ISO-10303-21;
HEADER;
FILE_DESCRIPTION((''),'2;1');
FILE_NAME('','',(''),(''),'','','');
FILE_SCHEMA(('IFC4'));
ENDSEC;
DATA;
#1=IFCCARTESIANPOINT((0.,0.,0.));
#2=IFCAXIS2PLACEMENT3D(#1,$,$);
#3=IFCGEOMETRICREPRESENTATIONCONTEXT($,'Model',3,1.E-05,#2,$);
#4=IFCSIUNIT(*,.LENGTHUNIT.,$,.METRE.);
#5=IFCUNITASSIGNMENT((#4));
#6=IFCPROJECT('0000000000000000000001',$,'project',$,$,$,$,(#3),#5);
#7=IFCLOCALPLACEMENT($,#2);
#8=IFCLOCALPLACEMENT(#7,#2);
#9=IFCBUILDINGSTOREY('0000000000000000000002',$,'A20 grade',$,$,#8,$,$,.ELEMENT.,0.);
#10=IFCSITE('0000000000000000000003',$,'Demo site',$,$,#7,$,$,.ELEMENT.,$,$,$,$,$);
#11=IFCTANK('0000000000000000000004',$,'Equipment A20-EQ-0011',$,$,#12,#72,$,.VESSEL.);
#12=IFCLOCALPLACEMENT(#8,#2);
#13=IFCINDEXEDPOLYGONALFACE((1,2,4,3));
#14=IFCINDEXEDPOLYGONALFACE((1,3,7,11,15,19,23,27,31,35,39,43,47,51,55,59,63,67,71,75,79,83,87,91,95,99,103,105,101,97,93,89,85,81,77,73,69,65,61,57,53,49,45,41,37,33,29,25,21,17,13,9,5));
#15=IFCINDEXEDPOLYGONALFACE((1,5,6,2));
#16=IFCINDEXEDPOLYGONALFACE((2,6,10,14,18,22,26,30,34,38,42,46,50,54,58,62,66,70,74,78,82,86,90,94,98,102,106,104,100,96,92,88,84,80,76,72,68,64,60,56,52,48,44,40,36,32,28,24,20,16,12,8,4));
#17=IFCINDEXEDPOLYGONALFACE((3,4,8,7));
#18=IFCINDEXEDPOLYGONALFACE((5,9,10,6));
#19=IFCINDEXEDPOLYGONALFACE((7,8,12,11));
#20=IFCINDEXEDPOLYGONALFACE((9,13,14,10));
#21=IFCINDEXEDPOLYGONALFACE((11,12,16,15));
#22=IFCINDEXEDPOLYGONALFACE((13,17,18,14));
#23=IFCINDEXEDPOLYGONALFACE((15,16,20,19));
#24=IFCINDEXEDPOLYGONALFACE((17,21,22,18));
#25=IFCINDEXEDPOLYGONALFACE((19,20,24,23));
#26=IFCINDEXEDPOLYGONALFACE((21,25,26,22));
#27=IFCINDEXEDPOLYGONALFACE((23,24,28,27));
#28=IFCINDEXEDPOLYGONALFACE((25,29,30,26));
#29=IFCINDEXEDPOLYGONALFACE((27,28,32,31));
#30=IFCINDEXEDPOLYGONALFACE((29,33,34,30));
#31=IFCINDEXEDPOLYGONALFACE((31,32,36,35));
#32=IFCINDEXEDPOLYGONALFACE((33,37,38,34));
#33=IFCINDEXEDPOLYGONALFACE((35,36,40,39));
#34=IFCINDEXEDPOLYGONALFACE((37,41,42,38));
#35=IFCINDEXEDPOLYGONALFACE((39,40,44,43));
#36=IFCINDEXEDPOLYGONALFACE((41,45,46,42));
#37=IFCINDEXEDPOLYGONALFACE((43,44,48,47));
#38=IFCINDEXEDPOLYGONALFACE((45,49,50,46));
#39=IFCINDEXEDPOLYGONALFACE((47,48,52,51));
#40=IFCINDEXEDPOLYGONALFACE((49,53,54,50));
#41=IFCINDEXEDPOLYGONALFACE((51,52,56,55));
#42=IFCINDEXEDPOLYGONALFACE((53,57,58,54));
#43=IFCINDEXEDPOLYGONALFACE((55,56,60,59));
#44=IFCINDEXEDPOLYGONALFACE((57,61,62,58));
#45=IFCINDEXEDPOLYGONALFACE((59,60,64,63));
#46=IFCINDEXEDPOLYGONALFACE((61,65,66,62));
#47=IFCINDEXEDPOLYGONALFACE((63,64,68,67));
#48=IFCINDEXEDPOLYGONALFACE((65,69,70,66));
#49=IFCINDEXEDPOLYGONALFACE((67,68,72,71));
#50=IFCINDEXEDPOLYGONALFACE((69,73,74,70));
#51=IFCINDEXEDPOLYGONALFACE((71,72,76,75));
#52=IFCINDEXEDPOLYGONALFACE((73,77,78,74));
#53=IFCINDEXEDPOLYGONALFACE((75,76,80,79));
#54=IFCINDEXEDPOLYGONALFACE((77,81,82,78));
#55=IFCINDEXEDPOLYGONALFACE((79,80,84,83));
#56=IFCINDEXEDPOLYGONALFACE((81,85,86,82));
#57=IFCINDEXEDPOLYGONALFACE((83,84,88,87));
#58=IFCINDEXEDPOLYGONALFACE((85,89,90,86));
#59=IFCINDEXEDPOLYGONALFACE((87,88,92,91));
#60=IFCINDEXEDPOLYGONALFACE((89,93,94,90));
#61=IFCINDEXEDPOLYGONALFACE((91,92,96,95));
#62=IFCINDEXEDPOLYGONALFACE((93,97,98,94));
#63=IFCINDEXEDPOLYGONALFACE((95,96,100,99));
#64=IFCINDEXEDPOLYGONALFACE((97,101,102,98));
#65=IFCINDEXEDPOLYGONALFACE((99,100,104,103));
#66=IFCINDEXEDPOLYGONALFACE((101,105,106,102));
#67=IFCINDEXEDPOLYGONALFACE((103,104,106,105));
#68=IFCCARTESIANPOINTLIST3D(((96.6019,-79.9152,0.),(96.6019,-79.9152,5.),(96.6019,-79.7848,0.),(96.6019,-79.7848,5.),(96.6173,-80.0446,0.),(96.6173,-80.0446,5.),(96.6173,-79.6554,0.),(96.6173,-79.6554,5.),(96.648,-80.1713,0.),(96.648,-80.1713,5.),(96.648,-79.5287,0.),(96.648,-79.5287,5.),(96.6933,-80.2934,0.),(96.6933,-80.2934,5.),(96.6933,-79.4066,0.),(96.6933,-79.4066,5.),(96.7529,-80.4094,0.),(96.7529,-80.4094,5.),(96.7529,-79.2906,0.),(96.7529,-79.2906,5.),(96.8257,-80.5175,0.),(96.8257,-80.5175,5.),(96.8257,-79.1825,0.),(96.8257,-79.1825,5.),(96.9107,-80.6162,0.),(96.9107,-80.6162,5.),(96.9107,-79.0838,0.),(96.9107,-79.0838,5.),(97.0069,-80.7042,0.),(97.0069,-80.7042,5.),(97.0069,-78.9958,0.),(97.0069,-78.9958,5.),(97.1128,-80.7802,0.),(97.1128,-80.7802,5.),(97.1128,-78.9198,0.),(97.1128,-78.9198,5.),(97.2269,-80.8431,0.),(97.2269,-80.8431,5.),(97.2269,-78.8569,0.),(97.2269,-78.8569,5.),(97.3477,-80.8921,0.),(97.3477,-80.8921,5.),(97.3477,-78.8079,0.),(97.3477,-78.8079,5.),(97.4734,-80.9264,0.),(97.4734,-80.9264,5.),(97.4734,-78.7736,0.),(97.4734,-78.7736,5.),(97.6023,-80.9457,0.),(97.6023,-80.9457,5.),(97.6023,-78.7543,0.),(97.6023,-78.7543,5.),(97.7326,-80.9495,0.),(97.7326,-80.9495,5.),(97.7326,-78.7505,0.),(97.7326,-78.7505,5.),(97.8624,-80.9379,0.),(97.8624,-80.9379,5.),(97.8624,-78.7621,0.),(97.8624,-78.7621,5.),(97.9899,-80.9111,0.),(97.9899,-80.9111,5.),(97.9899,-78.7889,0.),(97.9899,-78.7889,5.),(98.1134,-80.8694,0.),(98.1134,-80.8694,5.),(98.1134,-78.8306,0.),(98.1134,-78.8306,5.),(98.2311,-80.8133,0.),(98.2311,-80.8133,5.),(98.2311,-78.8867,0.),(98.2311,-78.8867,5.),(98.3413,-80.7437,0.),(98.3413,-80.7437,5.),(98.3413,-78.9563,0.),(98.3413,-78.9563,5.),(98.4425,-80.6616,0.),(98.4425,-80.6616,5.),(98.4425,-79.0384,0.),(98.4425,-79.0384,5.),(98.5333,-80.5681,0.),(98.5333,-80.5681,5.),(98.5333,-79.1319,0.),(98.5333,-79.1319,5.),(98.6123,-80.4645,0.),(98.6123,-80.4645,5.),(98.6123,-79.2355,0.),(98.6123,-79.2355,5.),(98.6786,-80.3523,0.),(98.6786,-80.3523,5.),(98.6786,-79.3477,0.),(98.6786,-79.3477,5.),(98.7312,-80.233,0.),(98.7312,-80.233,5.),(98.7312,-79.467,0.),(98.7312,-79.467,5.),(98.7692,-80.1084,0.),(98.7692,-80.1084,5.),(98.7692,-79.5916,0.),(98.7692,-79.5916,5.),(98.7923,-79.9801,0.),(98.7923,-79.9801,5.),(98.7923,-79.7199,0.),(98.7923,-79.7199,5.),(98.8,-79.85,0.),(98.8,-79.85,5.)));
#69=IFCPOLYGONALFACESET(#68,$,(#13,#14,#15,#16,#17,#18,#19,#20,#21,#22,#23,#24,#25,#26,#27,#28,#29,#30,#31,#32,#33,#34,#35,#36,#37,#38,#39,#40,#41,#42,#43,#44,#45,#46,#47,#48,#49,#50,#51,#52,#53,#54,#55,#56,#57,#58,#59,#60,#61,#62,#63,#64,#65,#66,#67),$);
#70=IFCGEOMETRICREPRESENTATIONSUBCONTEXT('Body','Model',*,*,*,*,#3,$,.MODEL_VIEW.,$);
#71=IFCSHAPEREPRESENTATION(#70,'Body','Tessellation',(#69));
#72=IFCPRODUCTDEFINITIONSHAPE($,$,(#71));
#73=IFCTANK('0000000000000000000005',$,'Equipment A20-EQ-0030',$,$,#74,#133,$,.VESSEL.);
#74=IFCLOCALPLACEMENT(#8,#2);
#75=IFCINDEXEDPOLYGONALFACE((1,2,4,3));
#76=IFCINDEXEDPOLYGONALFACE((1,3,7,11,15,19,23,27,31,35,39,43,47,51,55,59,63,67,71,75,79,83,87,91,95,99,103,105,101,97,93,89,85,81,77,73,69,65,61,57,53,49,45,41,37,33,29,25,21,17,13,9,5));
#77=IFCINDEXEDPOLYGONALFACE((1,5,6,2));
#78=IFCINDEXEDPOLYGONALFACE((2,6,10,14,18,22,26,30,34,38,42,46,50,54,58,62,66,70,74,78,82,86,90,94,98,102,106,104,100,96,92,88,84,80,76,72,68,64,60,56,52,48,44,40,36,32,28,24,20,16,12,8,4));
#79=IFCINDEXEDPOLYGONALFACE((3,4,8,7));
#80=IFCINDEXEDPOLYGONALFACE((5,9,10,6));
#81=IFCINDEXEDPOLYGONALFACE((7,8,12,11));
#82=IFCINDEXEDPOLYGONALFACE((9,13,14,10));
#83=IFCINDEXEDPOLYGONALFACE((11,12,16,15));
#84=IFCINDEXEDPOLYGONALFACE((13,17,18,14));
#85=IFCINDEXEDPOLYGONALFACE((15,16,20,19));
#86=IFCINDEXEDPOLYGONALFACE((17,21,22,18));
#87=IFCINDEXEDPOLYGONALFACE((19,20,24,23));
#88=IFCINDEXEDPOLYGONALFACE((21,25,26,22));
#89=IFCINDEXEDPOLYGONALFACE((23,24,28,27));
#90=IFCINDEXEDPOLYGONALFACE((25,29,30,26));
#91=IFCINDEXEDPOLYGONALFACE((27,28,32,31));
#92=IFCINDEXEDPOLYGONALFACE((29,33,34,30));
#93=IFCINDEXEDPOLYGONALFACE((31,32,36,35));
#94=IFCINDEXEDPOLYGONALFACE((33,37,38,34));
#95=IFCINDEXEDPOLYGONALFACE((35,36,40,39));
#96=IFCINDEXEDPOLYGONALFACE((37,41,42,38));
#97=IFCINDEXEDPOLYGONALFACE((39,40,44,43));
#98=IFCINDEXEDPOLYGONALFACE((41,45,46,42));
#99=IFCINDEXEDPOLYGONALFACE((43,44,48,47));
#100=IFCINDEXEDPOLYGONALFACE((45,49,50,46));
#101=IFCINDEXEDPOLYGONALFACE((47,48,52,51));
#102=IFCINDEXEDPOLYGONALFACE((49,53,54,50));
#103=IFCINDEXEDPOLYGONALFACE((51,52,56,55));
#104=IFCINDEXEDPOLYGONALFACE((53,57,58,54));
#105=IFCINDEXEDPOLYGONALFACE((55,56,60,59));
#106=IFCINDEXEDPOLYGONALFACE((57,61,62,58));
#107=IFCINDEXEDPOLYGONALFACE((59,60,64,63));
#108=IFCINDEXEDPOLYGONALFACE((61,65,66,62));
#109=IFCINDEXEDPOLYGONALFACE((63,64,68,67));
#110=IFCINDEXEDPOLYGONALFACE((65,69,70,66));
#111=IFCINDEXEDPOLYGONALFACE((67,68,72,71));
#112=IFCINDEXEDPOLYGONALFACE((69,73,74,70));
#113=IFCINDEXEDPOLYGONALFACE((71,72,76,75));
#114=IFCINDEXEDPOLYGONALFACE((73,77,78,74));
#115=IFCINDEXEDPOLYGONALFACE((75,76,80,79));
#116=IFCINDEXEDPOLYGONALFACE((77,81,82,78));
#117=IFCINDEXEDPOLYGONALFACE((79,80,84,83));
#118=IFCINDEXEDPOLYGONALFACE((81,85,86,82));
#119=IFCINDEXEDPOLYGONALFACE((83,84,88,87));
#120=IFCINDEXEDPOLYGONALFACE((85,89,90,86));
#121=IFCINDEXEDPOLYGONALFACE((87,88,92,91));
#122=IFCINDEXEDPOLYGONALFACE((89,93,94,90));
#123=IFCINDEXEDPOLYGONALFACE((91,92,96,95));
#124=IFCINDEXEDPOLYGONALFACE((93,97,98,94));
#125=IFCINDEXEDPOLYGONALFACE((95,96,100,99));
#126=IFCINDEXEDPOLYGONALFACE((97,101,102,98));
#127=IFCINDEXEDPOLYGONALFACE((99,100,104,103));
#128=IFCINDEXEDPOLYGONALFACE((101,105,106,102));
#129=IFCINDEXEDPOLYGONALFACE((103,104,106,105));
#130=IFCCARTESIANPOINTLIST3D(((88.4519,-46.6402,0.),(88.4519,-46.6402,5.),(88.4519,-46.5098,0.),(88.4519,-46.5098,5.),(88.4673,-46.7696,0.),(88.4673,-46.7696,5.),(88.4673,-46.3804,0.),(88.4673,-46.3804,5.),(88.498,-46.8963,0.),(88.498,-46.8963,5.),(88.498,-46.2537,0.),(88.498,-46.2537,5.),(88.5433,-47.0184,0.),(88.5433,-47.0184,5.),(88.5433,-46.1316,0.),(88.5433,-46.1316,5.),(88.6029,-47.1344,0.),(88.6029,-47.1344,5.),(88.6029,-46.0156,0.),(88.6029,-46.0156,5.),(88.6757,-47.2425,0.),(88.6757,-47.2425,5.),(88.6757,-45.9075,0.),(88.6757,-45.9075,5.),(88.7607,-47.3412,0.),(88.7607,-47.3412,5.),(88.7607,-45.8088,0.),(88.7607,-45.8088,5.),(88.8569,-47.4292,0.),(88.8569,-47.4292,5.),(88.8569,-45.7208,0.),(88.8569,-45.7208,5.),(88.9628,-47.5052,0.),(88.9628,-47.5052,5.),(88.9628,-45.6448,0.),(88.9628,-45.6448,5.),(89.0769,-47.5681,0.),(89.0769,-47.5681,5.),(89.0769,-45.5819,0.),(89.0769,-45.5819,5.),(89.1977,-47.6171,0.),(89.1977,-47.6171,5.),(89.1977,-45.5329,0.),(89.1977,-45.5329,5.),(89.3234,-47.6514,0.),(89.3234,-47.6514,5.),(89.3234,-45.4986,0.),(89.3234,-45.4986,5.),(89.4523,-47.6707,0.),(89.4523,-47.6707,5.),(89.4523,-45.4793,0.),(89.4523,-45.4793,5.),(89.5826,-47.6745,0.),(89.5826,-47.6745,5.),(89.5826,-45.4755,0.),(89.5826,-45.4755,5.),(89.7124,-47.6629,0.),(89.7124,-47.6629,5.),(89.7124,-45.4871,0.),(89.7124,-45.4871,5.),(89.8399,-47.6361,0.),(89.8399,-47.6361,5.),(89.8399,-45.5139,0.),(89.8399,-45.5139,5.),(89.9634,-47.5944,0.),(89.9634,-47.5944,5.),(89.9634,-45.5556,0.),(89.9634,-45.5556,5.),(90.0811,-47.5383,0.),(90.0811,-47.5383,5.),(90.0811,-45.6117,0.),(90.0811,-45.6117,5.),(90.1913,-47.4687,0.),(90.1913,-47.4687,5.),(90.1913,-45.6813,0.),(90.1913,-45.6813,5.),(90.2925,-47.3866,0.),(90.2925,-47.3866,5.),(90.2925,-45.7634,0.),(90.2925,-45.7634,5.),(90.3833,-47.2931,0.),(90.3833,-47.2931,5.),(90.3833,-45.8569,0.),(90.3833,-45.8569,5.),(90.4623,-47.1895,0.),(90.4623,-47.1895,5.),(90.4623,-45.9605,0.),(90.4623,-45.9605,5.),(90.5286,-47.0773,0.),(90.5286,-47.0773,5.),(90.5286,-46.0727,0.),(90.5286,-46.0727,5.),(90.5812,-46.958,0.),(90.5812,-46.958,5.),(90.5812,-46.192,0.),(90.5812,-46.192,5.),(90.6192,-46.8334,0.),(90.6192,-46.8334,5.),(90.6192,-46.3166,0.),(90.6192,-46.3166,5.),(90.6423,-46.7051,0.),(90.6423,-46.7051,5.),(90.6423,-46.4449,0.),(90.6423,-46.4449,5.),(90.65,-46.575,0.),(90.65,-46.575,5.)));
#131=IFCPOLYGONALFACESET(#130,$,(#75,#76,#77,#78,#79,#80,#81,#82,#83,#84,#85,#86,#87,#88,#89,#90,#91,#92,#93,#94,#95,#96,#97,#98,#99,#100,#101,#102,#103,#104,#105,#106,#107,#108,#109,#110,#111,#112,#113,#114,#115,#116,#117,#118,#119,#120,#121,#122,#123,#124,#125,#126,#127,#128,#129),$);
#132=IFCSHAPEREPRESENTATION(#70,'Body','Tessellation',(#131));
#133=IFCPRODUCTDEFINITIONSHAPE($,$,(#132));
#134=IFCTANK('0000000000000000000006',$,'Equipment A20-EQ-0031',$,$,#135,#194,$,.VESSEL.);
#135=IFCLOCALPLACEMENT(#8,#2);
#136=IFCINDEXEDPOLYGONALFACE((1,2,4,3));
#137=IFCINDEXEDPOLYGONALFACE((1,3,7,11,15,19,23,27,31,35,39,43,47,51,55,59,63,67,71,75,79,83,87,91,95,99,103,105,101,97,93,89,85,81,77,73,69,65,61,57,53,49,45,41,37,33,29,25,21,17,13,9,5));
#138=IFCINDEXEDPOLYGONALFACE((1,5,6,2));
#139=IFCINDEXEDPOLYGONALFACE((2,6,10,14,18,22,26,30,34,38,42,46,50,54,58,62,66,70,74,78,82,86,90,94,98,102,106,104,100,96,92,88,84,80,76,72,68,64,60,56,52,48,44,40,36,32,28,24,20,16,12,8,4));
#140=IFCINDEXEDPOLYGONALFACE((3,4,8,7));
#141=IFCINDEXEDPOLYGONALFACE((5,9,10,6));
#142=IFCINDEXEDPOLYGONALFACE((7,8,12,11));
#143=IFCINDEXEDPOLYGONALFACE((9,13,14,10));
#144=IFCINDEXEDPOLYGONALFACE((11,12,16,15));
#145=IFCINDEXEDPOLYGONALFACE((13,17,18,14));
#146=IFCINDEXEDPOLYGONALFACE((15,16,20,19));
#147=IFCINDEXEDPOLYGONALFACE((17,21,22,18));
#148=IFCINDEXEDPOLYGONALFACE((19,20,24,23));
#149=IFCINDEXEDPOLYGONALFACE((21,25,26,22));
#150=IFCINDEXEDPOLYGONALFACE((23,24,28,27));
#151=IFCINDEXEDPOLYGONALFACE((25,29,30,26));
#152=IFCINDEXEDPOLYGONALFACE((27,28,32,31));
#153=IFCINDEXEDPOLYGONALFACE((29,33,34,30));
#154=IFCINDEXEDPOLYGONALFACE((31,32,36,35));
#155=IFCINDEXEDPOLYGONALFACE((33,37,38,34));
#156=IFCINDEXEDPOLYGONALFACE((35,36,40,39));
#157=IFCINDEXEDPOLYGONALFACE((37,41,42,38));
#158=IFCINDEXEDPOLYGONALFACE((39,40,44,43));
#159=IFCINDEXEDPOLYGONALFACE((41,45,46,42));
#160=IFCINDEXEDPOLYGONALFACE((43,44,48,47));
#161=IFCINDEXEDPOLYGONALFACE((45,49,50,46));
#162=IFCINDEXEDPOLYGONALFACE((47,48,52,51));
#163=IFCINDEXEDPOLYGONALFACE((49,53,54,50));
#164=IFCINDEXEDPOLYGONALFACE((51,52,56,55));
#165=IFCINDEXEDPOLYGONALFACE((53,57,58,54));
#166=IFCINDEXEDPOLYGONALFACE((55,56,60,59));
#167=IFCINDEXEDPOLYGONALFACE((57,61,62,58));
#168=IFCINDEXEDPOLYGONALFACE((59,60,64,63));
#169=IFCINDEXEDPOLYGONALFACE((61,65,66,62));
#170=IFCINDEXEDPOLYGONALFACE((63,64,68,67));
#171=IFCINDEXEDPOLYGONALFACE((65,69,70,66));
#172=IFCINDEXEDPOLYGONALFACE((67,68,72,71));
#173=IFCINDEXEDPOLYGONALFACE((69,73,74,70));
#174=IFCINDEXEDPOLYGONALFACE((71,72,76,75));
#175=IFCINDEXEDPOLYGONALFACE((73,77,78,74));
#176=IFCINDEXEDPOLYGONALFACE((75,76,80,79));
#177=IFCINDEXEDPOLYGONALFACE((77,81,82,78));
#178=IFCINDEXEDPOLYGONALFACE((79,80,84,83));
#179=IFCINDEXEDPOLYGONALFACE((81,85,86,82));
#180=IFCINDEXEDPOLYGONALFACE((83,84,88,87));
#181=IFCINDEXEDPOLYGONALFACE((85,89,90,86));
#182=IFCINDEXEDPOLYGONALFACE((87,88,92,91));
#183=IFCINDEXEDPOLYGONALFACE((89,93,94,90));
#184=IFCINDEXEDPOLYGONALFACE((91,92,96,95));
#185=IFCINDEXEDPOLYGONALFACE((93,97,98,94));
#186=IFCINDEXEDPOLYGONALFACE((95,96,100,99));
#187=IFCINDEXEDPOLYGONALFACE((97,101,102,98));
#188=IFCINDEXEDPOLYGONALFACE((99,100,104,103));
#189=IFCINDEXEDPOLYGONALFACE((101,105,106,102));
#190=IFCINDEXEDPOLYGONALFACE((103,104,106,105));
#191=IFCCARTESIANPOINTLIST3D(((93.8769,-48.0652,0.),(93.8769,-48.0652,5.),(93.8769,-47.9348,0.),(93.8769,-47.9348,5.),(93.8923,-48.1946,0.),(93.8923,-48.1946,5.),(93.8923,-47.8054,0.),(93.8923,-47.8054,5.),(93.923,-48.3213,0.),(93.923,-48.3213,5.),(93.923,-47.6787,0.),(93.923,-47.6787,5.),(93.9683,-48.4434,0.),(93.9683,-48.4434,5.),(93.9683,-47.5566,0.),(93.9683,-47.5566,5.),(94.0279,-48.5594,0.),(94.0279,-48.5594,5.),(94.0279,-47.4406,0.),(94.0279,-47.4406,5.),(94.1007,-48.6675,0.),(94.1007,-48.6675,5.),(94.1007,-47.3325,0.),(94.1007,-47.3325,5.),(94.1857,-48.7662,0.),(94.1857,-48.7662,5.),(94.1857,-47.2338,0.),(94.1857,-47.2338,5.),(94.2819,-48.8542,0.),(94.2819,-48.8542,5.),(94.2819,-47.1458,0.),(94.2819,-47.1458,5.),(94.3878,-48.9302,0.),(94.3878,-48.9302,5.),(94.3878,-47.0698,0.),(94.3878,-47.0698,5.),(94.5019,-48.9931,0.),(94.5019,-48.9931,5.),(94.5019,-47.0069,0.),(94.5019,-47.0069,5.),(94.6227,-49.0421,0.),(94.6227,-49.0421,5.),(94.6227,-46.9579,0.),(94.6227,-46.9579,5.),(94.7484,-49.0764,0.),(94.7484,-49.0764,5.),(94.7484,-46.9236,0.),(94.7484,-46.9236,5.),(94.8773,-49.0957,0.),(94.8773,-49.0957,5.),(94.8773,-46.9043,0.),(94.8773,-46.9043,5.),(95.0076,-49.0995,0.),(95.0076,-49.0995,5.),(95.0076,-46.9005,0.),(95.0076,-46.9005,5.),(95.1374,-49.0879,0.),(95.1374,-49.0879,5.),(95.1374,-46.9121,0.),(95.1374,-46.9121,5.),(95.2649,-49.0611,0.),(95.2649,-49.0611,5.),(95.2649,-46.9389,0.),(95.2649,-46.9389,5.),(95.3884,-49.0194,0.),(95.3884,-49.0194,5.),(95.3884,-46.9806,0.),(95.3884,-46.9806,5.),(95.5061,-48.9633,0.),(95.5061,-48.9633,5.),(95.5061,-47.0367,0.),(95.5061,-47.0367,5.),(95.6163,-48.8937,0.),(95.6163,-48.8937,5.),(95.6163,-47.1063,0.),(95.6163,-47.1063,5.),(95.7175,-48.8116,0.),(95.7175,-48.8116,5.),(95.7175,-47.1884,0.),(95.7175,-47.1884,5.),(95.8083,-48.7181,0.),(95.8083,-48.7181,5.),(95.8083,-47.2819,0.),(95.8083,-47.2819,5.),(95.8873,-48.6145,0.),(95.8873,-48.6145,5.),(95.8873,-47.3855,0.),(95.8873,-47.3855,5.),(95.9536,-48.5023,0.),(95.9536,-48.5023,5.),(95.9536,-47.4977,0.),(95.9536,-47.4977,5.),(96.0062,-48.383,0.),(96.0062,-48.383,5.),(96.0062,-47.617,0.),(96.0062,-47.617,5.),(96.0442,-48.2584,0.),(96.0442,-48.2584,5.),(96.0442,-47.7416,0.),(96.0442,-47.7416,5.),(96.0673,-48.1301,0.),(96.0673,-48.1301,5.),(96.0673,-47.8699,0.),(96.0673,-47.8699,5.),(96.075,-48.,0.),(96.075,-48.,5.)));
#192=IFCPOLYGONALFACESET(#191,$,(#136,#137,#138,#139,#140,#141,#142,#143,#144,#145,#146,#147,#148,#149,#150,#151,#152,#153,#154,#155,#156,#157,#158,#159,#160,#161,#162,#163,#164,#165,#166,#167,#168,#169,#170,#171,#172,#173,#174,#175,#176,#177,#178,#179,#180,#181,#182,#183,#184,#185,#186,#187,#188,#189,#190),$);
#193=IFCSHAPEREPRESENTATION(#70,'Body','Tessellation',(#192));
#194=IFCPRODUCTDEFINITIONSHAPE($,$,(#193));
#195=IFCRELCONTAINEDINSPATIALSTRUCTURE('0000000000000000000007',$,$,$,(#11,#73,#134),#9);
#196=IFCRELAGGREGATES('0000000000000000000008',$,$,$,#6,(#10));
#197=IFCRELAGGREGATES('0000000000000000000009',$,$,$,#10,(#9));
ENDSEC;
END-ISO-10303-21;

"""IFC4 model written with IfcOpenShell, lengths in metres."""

from ifc_helpers import new_model, si_unit, frame, origin, place, context, subcontext, project, spatial, circle, extrude, element, save


model = new_model("IFC4")

# Units and contexts
model_context = context("Model", 3, precision=1e-05, world=origin())
body_context = subcontext(model_context, "Body", "Model", "MODEL_VIEW")
ifc_project = project(units=[si_unit("LENGTHUNIT", "METRE")], contexts=[model_context])

# Site, storey
site_placement = place(None, origin())
site = spatial("IfcSite", under=ifc_project, at=site_placement, Name="Demo site", CompositionType="ELEMENT")
storey_placement = place(site_placement, origin())
storey = spatial("IfcBuildingStorey", under=site, at=storey_placement, Name="A20 grade", CompositionType="ELEMENT", Elevation=0.0)

# Tanks
for number, where, name in (
    (1, (97.7, -79.85, 0.0), "Equipment A20-EQ-0011"),
    (2, (89.55, -46.575, 0.0), "Equipment A20-EQ-0030"),
    (3, (94.975, -48.0, 0.0), "Equipment A20-EQ-0031"),
):
    element("IfcTank", number, at=place(storey_placement, frame(where)), inside=storey, Name=name, PredefinedType="VESSEL", context=body_context, shape_type="SweptSolid", body=[
        extrude(circle(Radius=1.1), origin(), (0.0, 0.0, 1.0), 5.0),
    ])

save(model, "model.ifc")
